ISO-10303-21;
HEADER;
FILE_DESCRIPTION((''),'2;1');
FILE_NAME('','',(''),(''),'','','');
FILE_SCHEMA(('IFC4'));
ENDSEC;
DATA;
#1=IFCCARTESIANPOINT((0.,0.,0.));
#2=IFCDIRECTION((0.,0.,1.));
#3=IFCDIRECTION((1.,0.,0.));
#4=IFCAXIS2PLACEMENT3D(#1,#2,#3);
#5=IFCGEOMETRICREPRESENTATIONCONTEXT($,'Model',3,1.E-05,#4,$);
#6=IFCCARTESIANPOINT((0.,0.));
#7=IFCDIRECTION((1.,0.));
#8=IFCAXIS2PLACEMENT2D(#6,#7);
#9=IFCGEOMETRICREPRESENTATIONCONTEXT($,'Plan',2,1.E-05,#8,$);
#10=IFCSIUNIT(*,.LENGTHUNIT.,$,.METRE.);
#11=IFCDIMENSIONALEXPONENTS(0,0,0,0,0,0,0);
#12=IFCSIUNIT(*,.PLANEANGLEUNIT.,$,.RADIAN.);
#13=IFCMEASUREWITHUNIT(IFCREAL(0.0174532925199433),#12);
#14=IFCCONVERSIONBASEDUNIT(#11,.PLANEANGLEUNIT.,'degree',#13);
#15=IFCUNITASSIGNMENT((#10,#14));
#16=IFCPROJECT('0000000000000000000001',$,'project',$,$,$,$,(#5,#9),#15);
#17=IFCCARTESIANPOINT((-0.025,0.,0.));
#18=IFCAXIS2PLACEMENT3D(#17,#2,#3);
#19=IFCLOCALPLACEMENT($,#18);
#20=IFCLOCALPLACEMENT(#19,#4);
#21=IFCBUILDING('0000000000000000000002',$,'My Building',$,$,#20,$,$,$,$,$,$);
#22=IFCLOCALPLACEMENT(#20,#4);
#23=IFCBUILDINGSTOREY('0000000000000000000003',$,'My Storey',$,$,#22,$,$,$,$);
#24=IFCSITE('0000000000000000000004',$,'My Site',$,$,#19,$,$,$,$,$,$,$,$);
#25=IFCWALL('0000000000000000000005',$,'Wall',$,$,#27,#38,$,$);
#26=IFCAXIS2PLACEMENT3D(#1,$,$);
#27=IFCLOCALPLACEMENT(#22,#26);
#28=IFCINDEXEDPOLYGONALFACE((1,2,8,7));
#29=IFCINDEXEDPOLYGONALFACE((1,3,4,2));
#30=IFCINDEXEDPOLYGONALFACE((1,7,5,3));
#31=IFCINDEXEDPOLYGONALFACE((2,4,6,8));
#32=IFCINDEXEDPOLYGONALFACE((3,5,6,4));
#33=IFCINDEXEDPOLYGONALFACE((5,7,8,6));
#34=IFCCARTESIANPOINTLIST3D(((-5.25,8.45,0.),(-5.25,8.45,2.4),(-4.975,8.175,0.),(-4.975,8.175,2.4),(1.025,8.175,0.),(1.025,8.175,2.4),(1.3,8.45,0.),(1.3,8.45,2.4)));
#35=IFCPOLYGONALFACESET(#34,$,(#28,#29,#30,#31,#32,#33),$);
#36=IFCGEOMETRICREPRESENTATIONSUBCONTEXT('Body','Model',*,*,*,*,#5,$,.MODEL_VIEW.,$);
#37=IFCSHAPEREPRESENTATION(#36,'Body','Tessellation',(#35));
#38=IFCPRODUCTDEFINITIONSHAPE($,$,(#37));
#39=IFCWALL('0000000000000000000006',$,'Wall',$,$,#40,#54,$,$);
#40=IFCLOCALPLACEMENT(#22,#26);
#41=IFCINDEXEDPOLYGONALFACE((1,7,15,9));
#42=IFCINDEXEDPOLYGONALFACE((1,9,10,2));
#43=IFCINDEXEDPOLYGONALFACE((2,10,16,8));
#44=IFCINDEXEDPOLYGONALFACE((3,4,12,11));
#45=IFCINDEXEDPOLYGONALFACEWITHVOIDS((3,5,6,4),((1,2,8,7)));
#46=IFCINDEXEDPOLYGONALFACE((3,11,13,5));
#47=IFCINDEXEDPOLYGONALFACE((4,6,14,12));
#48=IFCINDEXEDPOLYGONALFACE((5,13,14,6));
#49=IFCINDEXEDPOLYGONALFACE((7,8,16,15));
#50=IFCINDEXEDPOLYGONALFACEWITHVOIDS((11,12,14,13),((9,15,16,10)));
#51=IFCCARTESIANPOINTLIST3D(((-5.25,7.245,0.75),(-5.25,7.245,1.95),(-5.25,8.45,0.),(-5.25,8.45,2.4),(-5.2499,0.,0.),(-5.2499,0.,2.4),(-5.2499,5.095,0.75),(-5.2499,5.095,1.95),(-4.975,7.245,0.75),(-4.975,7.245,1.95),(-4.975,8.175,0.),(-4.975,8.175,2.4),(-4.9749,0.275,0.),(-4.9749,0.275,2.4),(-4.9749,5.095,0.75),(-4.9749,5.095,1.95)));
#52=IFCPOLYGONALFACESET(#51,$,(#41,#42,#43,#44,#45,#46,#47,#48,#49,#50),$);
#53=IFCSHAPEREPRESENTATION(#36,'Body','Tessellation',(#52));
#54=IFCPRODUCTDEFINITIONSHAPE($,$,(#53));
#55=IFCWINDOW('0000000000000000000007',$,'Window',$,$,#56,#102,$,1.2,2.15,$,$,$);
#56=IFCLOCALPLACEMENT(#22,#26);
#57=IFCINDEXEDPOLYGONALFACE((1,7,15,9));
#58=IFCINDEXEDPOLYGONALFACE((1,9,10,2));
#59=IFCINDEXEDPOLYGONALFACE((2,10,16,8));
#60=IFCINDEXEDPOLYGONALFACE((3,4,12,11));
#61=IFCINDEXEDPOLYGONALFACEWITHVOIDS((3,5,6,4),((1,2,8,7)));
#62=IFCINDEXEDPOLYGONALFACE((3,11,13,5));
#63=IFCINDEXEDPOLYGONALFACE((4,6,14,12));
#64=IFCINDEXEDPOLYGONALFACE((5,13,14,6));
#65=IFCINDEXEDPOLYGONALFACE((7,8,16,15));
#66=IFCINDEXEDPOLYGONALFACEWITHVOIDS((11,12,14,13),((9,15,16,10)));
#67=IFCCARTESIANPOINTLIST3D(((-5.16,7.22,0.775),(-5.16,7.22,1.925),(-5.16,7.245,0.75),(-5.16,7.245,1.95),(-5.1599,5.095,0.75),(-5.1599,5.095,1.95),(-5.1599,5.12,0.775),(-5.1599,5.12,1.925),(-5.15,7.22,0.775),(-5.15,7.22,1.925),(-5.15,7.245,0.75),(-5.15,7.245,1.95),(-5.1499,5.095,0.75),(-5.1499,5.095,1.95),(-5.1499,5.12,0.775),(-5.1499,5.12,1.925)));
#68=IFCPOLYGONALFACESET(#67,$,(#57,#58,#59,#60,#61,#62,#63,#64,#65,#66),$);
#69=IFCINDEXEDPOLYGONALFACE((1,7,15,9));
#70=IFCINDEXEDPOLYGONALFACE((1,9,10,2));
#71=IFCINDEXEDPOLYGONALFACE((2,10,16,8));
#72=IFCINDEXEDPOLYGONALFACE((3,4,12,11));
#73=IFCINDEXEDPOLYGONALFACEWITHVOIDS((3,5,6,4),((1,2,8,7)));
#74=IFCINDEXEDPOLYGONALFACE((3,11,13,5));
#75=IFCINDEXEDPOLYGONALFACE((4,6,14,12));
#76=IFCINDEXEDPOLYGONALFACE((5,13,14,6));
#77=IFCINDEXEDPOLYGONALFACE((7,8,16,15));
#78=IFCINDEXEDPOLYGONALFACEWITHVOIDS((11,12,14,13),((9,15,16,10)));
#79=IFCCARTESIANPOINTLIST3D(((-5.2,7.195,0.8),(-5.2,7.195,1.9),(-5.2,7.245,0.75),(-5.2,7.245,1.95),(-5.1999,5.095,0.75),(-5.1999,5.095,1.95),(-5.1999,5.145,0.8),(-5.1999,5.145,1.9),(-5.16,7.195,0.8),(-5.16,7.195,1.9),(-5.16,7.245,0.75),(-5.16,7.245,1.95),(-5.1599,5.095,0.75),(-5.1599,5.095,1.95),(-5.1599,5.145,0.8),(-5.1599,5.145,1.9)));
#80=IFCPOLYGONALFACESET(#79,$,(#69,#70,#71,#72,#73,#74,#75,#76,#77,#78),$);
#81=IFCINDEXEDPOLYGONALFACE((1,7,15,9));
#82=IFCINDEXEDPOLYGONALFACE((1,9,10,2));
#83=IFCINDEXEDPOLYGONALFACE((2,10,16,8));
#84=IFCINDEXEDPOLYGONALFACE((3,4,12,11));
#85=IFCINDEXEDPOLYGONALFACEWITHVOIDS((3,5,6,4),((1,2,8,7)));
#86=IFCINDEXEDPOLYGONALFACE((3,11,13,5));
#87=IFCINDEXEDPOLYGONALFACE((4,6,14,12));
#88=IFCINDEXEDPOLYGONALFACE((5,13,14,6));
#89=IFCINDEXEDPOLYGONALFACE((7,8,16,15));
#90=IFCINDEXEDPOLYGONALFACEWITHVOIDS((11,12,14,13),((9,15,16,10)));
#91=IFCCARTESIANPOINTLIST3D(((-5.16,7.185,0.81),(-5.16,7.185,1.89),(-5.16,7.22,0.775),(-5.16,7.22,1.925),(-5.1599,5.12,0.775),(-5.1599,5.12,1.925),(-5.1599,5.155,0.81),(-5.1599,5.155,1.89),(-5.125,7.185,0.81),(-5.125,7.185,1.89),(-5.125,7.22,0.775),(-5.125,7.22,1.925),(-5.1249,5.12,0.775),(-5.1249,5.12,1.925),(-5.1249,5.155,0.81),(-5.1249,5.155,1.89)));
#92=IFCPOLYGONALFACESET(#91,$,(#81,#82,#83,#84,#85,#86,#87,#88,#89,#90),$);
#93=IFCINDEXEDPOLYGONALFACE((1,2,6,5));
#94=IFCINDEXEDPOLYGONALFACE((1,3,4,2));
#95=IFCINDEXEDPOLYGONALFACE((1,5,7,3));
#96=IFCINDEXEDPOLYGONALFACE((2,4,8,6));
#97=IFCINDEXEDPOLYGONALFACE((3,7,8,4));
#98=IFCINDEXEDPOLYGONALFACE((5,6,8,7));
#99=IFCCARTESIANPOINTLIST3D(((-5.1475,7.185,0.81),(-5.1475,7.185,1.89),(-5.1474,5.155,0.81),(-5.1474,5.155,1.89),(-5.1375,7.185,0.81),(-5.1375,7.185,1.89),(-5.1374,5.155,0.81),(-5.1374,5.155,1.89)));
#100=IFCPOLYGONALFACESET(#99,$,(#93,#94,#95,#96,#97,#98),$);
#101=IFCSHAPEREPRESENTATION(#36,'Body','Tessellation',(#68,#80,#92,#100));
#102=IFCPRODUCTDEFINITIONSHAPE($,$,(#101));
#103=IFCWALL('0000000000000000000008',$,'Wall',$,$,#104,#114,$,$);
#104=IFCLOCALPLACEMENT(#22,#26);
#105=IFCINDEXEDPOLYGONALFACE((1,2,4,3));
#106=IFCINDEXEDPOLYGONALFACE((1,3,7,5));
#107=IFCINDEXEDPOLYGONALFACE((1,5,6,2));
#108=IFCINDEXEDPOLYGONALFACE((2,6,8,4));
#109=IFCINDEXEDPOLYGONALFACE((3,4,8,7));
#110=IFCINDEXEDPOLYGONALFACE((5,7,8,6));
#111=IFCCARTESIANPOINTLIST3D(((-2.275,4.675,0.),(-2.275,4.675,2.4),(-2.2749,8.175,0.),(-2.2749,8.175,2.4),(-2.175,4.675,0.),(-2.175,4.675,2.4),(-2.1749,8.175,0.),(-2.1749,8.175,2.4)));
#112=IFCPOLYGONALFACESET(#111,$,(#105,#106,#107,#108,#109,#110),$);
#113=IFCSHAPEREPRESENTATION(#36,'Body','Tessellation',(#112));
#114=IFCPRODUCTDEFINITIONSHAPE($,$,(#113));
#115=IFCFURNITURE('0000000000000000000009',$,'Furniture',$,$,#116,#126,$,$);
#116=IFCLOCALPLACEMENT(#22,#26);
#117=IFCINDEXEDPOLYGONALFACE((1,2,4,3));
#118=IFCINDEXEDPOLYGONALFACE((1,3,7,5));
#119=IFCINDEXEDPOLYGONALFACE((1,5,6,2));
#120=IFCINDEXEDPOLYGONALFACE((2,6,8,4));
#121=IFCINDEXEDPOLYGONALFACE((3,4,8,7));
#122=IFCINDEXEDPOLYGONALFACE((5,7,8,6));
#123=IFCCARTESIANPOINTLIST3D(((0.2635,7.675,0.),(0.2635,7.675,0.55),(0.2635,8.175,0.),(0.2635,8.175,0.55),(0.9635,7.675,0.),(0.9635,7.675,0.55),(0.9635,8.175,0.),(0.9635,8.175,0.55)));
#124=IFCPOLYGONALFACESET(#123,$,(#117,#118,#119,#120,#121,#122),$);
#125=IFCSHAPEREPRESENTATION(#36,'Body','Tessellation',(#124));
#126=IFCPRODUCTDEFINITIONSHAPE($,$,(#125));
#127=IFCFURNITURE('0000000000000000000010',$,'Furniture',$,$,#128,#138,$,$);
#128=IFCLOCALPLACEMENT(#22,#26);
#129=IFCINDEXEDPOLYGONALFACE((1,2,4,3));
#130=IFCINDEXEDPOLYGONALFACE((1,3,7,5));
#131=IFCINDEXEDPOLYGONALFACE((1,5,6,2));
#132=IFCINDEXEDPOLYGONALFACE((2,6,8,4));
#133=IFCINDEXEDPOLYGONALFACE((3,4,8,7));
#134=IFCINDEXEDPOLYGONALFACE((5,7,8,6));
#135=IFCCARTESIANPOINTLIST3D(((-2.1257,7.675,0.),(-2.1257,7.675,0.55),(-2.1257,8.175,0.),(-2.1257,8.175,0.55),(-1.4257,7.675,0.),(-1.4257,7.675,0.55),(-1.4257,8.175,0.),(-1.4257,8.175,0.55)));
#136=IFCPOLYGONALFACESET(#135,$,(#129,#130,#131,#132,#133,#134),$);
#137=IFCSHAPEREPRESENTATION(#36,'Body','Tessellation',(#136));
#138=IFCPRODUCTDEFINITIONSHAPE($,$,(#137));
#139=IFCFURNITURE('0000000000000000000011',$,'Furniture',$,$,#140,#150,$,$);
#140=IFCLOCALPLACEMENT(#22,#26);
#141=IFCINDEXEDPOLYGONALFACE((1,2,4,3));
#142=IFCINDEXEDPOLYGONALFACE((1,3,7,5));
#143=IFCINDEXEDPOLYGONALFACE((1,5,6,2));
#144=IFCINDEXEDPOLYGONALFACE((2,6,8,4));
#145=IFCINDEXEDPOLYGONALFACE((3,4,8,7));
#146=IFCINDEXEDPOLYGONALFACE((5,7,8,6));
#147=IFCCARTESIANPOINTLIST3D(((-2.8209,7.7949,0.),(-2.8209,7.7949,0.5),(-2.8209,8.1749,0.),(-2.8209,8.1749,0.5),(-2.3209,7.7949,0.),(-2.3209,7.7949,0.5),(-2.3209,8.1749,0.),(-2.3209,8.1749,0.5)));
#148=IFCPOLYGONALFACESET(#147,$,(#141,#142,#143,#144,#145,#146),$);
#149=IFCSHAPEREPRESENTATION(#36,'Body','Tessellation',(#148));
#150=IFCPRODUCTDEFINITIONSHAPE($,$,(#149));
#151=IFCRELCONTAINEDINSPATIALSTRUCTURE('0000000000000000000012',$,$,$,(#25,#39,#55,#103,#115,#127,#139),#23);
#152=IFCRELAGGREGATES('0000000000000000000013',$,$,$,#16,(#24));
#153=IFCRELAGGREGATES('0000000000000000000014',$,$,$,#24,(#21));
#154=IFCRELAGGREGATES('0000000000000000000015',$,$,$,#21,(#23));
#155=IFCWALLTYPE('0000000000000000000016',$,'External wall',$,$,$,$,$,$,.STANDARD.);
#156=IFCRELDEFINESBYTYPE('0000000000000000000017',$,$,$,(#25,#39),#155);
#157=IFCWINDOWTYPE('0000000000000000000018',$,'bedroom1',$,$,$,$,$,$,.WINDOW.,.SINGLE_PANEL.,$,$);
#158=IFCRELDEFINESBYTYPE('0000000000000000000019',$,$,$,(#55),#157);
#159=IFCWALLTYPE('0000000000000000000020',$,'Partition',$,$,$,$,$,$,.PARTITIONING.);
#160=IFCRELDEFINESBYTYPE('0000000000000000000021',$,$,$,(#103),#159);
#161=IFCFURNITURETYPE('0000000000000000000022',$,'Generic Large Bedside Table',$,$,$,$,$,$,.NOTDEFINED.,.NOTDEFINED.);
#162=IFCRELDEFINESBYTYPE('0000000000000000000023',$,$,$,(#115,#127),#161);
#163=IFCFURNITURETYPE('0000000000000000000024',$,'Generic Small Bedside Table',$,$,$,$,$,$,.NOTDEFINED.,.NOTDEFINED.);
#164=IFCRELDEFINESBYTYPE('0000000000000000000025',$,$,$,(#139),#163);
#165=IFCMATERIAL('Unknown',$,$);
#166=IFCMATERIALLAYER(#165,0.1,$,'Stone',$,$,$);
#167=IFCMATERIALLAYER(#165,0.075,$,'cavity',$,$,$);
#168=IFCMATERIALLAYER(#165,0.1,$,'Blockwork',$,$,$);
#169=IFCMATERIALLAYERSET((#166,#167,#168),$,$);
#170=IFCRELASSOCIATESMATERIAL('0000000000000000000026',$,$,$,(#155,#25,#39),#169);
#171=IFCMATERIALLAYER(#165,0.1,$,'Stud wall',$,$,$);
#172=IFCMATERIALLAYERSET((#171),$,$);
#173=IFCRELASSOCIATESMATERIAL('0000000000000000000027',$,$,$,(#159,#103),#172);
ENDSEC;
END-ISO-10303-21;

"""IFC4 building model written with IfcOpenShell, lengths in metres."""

from ifc_helpers import new_model, entity, si_unit, converted_unit, frame, origin_with_axes, origin_2d_with_axis, place, context, subcontext, project, spatial, line, indexed_curve, outline, extrude, clip, halfspace, shape, source, transform, mapped, material, layer, layer_set, layer_usage, type_object, type_shapes, element, fill, save


model = new_model("IFC4")

# Units and contexts
model_context = context("Model", 3, precision=1e-05, world=origin_with_axes())
plan_context = context("Plan", 2, precision=1e-05, world=origin_2d_with_axis())
body_context_1 = subcontext(model_context, "Body", "Model", "MODEL_VIEW")
body_context_2 = subcontext(plan_context, "Body", "Plan", "PLAN_VIEW")
ifc_project = project(units=[si_unit("LENGTHUNIT", "METRE"), converted_unit("PLANEANGLEUNIT", "degree", entity("IfcReal", 0.0174532925199433), si_unit("PLANEANGLEUNIT", "RADIAN"), dimensions=[0, 0, 0, 0, 0, 0, 0])], contexts=[model_context, plan_context])

# Site, building, storey
site_placement = place(None, frame((-0.025, 0.0, 0.0), z_axis=(0.0, 0.0, 1.0), x_axis=(1.0, 0.0, 0.0)))
site = spatial("IfcSite", under=ifc_project, at=site_placement, Name="My Site")
building_placement = place(site_placement, origin_with_axes())
building = spatial("IfcBuilding", under=site, at=building_placement, Name="My Building")
storey_placement = place(building_placement, origin_with_axes())
storey = spatial("IfcBuildingStorey", under=building, at=storey_placement, Name="My Storey")

# Wall
ifc_material = material(Name="Unknown")
ifc_layer_1 = layer(ifc_material, 0.1, Name="Stone")
ifc_layer_2 = layer(ifc_material, 0.075, Name="cavity")
ifc_layer_3 = layer(ifc_material, 0.1, Name="Blockwork")
ifc_layer_set_1 = layer_set([ifc_layer_1, ifc_layer_2, ifc_layer_3])
ifc_layer_usage_1 = layer_usage(ifc_layer_set_1, "AXIS2", "POSITIVE", 0.0)
wall_type_1 = type_object("IfcWallType", Name="External wall", PredefinedType="STANDARD", material=ifc_layer_set_1)
wall_1_placement = place(storey_placement, frame((1.3, 8.45, 0.0), z_axis=(0.0, 0.0, 1.0), x_axis=(-1.0, 0.0, 0.0)))
element("IfcWall", 1, at=wall_1_placement, inside=storey, type_object=wall_type_1, material=ifc_layer_usage_1, Name="Wall", context=body_context_1, shape_type="Clipping", body=[
    clip(clip(extrude(outline(indexed_curve([(0.0, 0.0), (0.0, 0.275), (6.55, 0.275), (6.55, 0.0), (0.0, 0.0)], self_intersect=False)), origin_with_axes(), (0.0, 0.0, 1.0), 2.4), halfspace(frame((6.55, 0.0, 0.0), z_axis=(0.707106, 0.707107, 0.0), x_axis=(-0.707107, 0.707106, 0.0)), False)), halfspace(frame((0.0, 0.0, 0.0), z_axis=(-0.707106, 0.707107, 0.0), x_axis=(0.707107, 0.707106, 0.0)), False)),
])

# Wall, opening, window
ifc_layer_usage_2 = layer_usage(ifc_layer_set_1, "AXIS2", "POSITIVE", 0.0)
wall_2_placement = place(storey_placement, frame((-5.25, 8.45, 0.0), z_axis=(0.0, 0.0, 1.0), x_axis=(0.0, -1.0, 0.0)))
wall_2 = element("IfcWall", 2, at=wall_2_placement, inside=storey, type_object=wall_type_1, material=ifc_layer_usage_2, Name="Wall", context=body_context_1, shape_type="Clipping", body=[
    clip(clip(extrude(outline(indexed_curve([(0.0, 0.0), (0.0, 0.275), (8.45, 0.275), (8.45, 0.0), (0.0, 0.0)], self_intersect=False)), origin_with_axes(), (0.0, 0.0, 1.0), 2.4), halfspace(frame((0.0, 0.0, 0.0), z_axis=(-0.707107, 0.707106, 0.0), x_axis=(0.707106, 0.707107, 0.0)), False)), halfspace(frame((8.45, 0.0, 0.0), z_axis=(0.707107, 0.707106, 0.0), x_axis=(-0.707106, 0.707107, 0.0)), False)),
])
shared_shape_1 = source(origin_with_axes(), body_context_1, "Body", "SweptSolid", [
    extrude(outline(indexed_curve([(0.0, 0.0), (2.15, 0.0), (2.15, 1.2), (0.0, 1.2)], segments=[line(1, 2, 3, 4, 1)])), frame((0.0, -0.1, 0.0), z_axis=(0.0, -1.0, 0.0), x_axis=(1.0, 0.0, 0.0)), (0.0, 0.0, -1.0), 0.475),
])
opening_1_placement = place(wall_2_placement, frame((1.205, 0.0, 0.75), z_axis=(0.0, 0.0, 1.0), x_axis=(1.0, 0.0, 0.0)))
opening_1 = element("IfcOpeningElement", 3, at=opening_1_placement, cuts=wall_2, PredefinedType="OPENING", context=body_context_1, shape_type="MappedRepresentation", body=[
    mapped(shared_shape_1, transform((0.0, 0.0, 0.0), x_axis=(1.0, 0.0, 0.0), y_axis=(0.0, 1.0, 0.0), z_axis=(0.0, 0.0, 1.0), scale=1.0)),
])
window_type = type_object("IfcWindowType", Name="bedroom1", PartitioningType="SINGLE_PANEL", PredefinedType="WINDOW")
shared_shape_2 = source(origin_with_axes(), body_context_1, "Body", "SweptSolid", [
    extrude(outline(indexed_curve([(0.0, 0.0), (2.15, 0.0), (2.15, 1.2), (0.0, 1.2)], segments=[line(1, 2, 3, 4, 1)]), holes=[indexed_curve([(0.025, 0.025), (2.125, 0.025), (2.125, 1.175), (0.025, 1.175)], segments=[line(1, 2, 3, 4, 1)])]), frame((0.0, 0.09, 0.0), z_axis=(0.0, -1.0, 0.0), x_axis=(1.0, 0.0, 0.0)), (0.0, 0.0, -1.0), 0.01),
    extrude(outline(indexed_curve([(0.0, 0.0), (2.15, 0.0), (2.15, 1.2), (0.0, 1.2)], segments=[line(1, 2, 3, 4, 1)]), holes=[indexed_curve([(0.05, 0.05), (2.1, 0.05), (2.1, 1.15), (0.05, 1.15)], segments=[line(1, 2, 3, 4, 1)])]), frame((0.0, 0.05, 0.0), z_axis=(0.0, -1.0, 0.0), x_axis=(1.0, 0.0, 0.0)), (0.0, 0.0, -1.0), 0.04),
    extrude(outline(indexed_curve([(0.0, 0.0), (2.1, 0.0), (2.1, 1.15), (0.0, 1.15)], segments=[line(1, 2, 3, 4, 1)]), holes=[indexed_curve([(0.035, 0.035), (2.065, 0.035), (2.065, 1.115), (0.035, 1.115)], segments=[line(1, 2, 3, 4, 1)])]), frame((0.025, 0.09, 0.025), z_axis=(0.0, -1.0, 0.0), x_axis=(1.0, 0.0, 0.0)), (0.0, 0.0, -1.0), 0.035),
    extrude(outline(indexed_curve([(0.035, 0.035), (2.065, 0.035), (2.065, 1.115), (0.035, 1.115)], segments=[line(1, 2, 3, 4, 1)])), frame((0.025, 0.1025, 0.025), z_axis=(0.0, -1.0, 0.0), x_axis=(1.0, 0.0, 0.0)), (0.0, 0.0, -1.0), 0.01),
])
shared_shape_3 = source(origin_with_axes(), body_context_2, "Body", "Curve2D", [
    entity("IfcIndexedPolyCurve", entity("IfcCartesianPointList2D", [[0.05, 0.05], [2.1, 0.05]])),
    entity("IfcIndexedPolyCurve", entity("IfcCartesianPointList2D", [[0.0, 0.1], [0.025, 0.1], [0.025, 0.09], [0.05, 0.09], [0.05, 0.05], [0.0, 0.05]]), [entity("IfcLineIndex", [1, 2, 3, 4, 5, 6, 1])]),
    entity("IfcIndexedPolyCurve", entity("IfcCartesianPointList2D", [[2.15, 0.1], [2.125, 0.1], [2.125, 0.09], [2.1, 0.09], [2.1, 0.05], [2.15, 0.05]]), [entity("IfcLineIndex", [1, 2, 3, 4, 5, 6, 1])]),
    entity("IfcIndexedPolyCurve", entity("IfcCartesianPointList2D", [[0.025, 0.09], [0.06, 0.09], [0.06, 0.125], [0.025, 0.125]]), [entity("IfcLineIndex", [1, 2, 3, 4, 1])]),
    entity("IfcIndexedPolyCurve", entity("IfcCartesianPointList2D", [[2.125, 0.09], [2.09, 0.09], [2.09, 0.125], [2.125, 0.125]]), [entity("IfcLineIndex", [1, 2, 3, 4, 1])]),
    entity("IfcIndexedPolyCurve", entity("IfcCartesianPointList2D", [[0.06, 0.09], [2.09, 0.09]])),
    entity("IfcIndexedPolyCurve", entity("IfcCartesianPointList2D", [[0.06, 0.125], [2.09, 0.125]])),
    entity("IfcIndexedPolyCurve", entity("IfcCartesianPointList2D", [[0.06, 0.1075], [2.09, 0.1075]])),
])
type_shapes(window_type, [shared_shape_2, shared_shape_3])
window_placement = place(opening_1_placement, frame((0.0, 0.0, 0.0), z_axis=(0.0, 0.0, 1.0), x_axis=(1.0, 0.0, 0.0)))
window = element("IfcWindow", 4, at=window_placement, inside=storey, type_object=window_type, Name="Window", OverallHeight=1.2, OverallWidth=2.15, shapes=[
    shape(body_context_1, "Body", "MappedRepresentation", [mapped(shared_shape_2, transform((0.0, 0.0, 0.0), x_axis=(1.0, 0.0, 0.0), y_axis=(0.0, 1.0, 0.0), z_axis=(0.0, 0.0, 1.0), scale=1.0))]),
    shape(body_context_2, "Body", "MappedRepresentation", [mapped(shared_shape_3, transform((0.0, 0.0, 0.0), x_axis=(1.0, 0.0, 0.0), y_axis=(0.0, 1.0, 0.0), z_axis=(0.0, 0.0, 1.0), scale=1.0))]),
])
fill(opening_1, window)

# Shared definitions
ifc_layer_4 = layer(ifc_material, 0.1, Name="Stud wall")
ifc_layer_set_2 = layer_set([ifc_layer_4])
wall_type_2 = type_object("IfcWallType", Name="Partition", PredefinedType="PARTITIONING", material=ifc_layer_set_2)

# Wall
ifc_layer_usage_3 = layer_usage(ifc_layer_set_2, "AXIS2", "POSITIVE", 0.0)
wall_3_placement = place(storey_placement, frame((-2.175, 4.675, 0.0), z_axis=(0.0, 0.0, 1.0), x_axis=(0.0, 1.0, 0.0)))
element("IfcWall", 5, at=wall_3_placement, inside=storey, type_object=wall_type_2, material=ifc_layer_usage_3, Name="Wall", context=body_context_1, shape_type="SweptSolid", body=[
    extrude(outline(indexed_curve([(0.0, 0.0), (0.0, 0.1), (3.5, 0.1), (3.5, 0.0), (0.0, 0.0)], self_intersect=False)), origin_with_axes(), (0.0, 0.0, 1.0), 2.4),
])

# Furniture
furniture_type_1 = type_object("IfcFurnitureType", Name="Generic Large Bedside Table", AssemblyPlace="NOTDEFINED", PredefinedType="NOTDEFINED")
shared_shape_4 = source(origin_with_axes(), body_context_1, "Body", "SweptSolid", [
    extrude(outline(indexed_curve([(0.0, 0.0), (0.7, 0.0), (0.7, 0.5), (0.0, 0.5)], segments=[line(1, 2, 3, 4, 1)])), frame((-0.35, -0.25, 0.0), z_axis=(0.0, 0.0, 1.0), x_axis=(1.0, 0.0, 0.0)), (0.0, 0.0, 1.0), 0.55),
])
shared_shape_5 = source(origin_with_axes(), body_context_2, "Body", "Curve2D", [
    entity("IfcIndexedPolyCurve", entity("IfcCartesianPointList2D", [[-0.35, -0.25], [0.35, -0.25], [0.35, 0.25], [-0.35, 0.25]]), [entity("IfcLineIndex", [1, 2, 3, 4, 1])]),
])
type_shapes(furniture_type_1, [shared_shape_4, shared_shape_5])
for number, where, z_axis, x_axis, name in (
    (6, (0.6135, 7.925, 0.0), (0.0, 0.0, 1.0), (1.0, 0.0, 0.0), "Furniture"),
    (7, (-1.7757, 7.925, 0.0), (0.0, 0.0, 1.0), (1.0, 0.0, 0.0), "Furniture"),
):
    element("IfcFurniture", number, at=place(storey_placement, frame(where, z_axis=z_axis, x_axis=x_axis)), inside=storey, type_object=furniture_type_1, Name=name, shapes=[
        shape(body_context_1, "Body", "MappedRepresentation", [mapped(shared_shape_4, transform((0.0, 0.0, 0.0), x_axis=(1.0, 0.0, 0.0), y_axis=(0.0, 1.0, 0.0), z_axis=(0.0, 0.0, 1.0), scale=1.0))]),
        shape(body_context_2, "Body", "MappedRepresentation", [mapped(shared_shape_5, transform((0.0, 0.0, 0.0), x_axis=(1.0, 0.0, 0.0), y_axis=(0.0, 1.0, 0.0), z_axis=(0.0, 0.0, 1.0), scale=1.0))]),
    ])
furniture_type_2 = type_object("IfcFurnitureType", Name="Generic Small Bedside Table", AssemblyPlace="NOTDEFINED", PredefinedType="NOTDEFINED")
shared_shape_6 = source(origin_with_axes(), body_context_1, "Body", "SweptSolid", [
    extrude(outline(indexed_curve([(0.0, 0.0), (0.5, 0.0), (0.5, 0.38), (0.0, 0.38)], segments=[line(1, 2, 3, 4, 1)])), frame((-0.25, -0.19, 0.0), z_axis=(0.0, 0.0, 1.0), x_axis=(1.0, 0.0, 0.0)), (0.0, 0.0, 1.0), 0.5),
])
shared_shape_7 = source(origin_with_axes(), body_context_2, "Body", "Curve2D", [
    entity("IfcIndexedPolyCurve", entity("IfcCartesianPointList2D", [[-0.25, -0.19], [0.25, -0.19], [0.25, 0.19], [-0.25, 0.19]]), [entity("IfcLineIndex", [1, 2, 3, 4, 1])]),
])
type_shapes(furniture_type_2, [shared_shape_6, shared_shape_7])
for number, where, z_axis, x_axis, name in (
    (8, (-2.5709, 7.9849, 0.0), (0.0, 0.0, 1.0), (1.0, 0.0, 0.0), "Furniture"),
):
    element("IfcFurniture", number, at=place(storey_placement, frame(where, z_axis=z_axis, x_axis=x_axis)), inside=storey, type_object=furniture_type_2, Name=name, shapes=[
        shape(body_context_1, "Body", "MappedRepresentation", [mapped(shared_shape_6, transform((0.0, 0.0, 0.0), x_axis=(1.0, 0.0, 0.0), y_axis=(0.0, 1.0, 0.0), z_axis=(0.0, 0.0, 1.0), scale=1.0))]),
        shape(body_context_2, "Body", "MappedRepresentation", [mapped(shared_shape_7, transform((0.0, 0.0, 0.0), x_axis=(1.0, 0.0, 0.0), y_axis=(0.0, 1.0, 0.0), z_axis=(0.0, 0.0, 1.0), scale=1.0))]),
    ])

save(model, "model.ifc")
